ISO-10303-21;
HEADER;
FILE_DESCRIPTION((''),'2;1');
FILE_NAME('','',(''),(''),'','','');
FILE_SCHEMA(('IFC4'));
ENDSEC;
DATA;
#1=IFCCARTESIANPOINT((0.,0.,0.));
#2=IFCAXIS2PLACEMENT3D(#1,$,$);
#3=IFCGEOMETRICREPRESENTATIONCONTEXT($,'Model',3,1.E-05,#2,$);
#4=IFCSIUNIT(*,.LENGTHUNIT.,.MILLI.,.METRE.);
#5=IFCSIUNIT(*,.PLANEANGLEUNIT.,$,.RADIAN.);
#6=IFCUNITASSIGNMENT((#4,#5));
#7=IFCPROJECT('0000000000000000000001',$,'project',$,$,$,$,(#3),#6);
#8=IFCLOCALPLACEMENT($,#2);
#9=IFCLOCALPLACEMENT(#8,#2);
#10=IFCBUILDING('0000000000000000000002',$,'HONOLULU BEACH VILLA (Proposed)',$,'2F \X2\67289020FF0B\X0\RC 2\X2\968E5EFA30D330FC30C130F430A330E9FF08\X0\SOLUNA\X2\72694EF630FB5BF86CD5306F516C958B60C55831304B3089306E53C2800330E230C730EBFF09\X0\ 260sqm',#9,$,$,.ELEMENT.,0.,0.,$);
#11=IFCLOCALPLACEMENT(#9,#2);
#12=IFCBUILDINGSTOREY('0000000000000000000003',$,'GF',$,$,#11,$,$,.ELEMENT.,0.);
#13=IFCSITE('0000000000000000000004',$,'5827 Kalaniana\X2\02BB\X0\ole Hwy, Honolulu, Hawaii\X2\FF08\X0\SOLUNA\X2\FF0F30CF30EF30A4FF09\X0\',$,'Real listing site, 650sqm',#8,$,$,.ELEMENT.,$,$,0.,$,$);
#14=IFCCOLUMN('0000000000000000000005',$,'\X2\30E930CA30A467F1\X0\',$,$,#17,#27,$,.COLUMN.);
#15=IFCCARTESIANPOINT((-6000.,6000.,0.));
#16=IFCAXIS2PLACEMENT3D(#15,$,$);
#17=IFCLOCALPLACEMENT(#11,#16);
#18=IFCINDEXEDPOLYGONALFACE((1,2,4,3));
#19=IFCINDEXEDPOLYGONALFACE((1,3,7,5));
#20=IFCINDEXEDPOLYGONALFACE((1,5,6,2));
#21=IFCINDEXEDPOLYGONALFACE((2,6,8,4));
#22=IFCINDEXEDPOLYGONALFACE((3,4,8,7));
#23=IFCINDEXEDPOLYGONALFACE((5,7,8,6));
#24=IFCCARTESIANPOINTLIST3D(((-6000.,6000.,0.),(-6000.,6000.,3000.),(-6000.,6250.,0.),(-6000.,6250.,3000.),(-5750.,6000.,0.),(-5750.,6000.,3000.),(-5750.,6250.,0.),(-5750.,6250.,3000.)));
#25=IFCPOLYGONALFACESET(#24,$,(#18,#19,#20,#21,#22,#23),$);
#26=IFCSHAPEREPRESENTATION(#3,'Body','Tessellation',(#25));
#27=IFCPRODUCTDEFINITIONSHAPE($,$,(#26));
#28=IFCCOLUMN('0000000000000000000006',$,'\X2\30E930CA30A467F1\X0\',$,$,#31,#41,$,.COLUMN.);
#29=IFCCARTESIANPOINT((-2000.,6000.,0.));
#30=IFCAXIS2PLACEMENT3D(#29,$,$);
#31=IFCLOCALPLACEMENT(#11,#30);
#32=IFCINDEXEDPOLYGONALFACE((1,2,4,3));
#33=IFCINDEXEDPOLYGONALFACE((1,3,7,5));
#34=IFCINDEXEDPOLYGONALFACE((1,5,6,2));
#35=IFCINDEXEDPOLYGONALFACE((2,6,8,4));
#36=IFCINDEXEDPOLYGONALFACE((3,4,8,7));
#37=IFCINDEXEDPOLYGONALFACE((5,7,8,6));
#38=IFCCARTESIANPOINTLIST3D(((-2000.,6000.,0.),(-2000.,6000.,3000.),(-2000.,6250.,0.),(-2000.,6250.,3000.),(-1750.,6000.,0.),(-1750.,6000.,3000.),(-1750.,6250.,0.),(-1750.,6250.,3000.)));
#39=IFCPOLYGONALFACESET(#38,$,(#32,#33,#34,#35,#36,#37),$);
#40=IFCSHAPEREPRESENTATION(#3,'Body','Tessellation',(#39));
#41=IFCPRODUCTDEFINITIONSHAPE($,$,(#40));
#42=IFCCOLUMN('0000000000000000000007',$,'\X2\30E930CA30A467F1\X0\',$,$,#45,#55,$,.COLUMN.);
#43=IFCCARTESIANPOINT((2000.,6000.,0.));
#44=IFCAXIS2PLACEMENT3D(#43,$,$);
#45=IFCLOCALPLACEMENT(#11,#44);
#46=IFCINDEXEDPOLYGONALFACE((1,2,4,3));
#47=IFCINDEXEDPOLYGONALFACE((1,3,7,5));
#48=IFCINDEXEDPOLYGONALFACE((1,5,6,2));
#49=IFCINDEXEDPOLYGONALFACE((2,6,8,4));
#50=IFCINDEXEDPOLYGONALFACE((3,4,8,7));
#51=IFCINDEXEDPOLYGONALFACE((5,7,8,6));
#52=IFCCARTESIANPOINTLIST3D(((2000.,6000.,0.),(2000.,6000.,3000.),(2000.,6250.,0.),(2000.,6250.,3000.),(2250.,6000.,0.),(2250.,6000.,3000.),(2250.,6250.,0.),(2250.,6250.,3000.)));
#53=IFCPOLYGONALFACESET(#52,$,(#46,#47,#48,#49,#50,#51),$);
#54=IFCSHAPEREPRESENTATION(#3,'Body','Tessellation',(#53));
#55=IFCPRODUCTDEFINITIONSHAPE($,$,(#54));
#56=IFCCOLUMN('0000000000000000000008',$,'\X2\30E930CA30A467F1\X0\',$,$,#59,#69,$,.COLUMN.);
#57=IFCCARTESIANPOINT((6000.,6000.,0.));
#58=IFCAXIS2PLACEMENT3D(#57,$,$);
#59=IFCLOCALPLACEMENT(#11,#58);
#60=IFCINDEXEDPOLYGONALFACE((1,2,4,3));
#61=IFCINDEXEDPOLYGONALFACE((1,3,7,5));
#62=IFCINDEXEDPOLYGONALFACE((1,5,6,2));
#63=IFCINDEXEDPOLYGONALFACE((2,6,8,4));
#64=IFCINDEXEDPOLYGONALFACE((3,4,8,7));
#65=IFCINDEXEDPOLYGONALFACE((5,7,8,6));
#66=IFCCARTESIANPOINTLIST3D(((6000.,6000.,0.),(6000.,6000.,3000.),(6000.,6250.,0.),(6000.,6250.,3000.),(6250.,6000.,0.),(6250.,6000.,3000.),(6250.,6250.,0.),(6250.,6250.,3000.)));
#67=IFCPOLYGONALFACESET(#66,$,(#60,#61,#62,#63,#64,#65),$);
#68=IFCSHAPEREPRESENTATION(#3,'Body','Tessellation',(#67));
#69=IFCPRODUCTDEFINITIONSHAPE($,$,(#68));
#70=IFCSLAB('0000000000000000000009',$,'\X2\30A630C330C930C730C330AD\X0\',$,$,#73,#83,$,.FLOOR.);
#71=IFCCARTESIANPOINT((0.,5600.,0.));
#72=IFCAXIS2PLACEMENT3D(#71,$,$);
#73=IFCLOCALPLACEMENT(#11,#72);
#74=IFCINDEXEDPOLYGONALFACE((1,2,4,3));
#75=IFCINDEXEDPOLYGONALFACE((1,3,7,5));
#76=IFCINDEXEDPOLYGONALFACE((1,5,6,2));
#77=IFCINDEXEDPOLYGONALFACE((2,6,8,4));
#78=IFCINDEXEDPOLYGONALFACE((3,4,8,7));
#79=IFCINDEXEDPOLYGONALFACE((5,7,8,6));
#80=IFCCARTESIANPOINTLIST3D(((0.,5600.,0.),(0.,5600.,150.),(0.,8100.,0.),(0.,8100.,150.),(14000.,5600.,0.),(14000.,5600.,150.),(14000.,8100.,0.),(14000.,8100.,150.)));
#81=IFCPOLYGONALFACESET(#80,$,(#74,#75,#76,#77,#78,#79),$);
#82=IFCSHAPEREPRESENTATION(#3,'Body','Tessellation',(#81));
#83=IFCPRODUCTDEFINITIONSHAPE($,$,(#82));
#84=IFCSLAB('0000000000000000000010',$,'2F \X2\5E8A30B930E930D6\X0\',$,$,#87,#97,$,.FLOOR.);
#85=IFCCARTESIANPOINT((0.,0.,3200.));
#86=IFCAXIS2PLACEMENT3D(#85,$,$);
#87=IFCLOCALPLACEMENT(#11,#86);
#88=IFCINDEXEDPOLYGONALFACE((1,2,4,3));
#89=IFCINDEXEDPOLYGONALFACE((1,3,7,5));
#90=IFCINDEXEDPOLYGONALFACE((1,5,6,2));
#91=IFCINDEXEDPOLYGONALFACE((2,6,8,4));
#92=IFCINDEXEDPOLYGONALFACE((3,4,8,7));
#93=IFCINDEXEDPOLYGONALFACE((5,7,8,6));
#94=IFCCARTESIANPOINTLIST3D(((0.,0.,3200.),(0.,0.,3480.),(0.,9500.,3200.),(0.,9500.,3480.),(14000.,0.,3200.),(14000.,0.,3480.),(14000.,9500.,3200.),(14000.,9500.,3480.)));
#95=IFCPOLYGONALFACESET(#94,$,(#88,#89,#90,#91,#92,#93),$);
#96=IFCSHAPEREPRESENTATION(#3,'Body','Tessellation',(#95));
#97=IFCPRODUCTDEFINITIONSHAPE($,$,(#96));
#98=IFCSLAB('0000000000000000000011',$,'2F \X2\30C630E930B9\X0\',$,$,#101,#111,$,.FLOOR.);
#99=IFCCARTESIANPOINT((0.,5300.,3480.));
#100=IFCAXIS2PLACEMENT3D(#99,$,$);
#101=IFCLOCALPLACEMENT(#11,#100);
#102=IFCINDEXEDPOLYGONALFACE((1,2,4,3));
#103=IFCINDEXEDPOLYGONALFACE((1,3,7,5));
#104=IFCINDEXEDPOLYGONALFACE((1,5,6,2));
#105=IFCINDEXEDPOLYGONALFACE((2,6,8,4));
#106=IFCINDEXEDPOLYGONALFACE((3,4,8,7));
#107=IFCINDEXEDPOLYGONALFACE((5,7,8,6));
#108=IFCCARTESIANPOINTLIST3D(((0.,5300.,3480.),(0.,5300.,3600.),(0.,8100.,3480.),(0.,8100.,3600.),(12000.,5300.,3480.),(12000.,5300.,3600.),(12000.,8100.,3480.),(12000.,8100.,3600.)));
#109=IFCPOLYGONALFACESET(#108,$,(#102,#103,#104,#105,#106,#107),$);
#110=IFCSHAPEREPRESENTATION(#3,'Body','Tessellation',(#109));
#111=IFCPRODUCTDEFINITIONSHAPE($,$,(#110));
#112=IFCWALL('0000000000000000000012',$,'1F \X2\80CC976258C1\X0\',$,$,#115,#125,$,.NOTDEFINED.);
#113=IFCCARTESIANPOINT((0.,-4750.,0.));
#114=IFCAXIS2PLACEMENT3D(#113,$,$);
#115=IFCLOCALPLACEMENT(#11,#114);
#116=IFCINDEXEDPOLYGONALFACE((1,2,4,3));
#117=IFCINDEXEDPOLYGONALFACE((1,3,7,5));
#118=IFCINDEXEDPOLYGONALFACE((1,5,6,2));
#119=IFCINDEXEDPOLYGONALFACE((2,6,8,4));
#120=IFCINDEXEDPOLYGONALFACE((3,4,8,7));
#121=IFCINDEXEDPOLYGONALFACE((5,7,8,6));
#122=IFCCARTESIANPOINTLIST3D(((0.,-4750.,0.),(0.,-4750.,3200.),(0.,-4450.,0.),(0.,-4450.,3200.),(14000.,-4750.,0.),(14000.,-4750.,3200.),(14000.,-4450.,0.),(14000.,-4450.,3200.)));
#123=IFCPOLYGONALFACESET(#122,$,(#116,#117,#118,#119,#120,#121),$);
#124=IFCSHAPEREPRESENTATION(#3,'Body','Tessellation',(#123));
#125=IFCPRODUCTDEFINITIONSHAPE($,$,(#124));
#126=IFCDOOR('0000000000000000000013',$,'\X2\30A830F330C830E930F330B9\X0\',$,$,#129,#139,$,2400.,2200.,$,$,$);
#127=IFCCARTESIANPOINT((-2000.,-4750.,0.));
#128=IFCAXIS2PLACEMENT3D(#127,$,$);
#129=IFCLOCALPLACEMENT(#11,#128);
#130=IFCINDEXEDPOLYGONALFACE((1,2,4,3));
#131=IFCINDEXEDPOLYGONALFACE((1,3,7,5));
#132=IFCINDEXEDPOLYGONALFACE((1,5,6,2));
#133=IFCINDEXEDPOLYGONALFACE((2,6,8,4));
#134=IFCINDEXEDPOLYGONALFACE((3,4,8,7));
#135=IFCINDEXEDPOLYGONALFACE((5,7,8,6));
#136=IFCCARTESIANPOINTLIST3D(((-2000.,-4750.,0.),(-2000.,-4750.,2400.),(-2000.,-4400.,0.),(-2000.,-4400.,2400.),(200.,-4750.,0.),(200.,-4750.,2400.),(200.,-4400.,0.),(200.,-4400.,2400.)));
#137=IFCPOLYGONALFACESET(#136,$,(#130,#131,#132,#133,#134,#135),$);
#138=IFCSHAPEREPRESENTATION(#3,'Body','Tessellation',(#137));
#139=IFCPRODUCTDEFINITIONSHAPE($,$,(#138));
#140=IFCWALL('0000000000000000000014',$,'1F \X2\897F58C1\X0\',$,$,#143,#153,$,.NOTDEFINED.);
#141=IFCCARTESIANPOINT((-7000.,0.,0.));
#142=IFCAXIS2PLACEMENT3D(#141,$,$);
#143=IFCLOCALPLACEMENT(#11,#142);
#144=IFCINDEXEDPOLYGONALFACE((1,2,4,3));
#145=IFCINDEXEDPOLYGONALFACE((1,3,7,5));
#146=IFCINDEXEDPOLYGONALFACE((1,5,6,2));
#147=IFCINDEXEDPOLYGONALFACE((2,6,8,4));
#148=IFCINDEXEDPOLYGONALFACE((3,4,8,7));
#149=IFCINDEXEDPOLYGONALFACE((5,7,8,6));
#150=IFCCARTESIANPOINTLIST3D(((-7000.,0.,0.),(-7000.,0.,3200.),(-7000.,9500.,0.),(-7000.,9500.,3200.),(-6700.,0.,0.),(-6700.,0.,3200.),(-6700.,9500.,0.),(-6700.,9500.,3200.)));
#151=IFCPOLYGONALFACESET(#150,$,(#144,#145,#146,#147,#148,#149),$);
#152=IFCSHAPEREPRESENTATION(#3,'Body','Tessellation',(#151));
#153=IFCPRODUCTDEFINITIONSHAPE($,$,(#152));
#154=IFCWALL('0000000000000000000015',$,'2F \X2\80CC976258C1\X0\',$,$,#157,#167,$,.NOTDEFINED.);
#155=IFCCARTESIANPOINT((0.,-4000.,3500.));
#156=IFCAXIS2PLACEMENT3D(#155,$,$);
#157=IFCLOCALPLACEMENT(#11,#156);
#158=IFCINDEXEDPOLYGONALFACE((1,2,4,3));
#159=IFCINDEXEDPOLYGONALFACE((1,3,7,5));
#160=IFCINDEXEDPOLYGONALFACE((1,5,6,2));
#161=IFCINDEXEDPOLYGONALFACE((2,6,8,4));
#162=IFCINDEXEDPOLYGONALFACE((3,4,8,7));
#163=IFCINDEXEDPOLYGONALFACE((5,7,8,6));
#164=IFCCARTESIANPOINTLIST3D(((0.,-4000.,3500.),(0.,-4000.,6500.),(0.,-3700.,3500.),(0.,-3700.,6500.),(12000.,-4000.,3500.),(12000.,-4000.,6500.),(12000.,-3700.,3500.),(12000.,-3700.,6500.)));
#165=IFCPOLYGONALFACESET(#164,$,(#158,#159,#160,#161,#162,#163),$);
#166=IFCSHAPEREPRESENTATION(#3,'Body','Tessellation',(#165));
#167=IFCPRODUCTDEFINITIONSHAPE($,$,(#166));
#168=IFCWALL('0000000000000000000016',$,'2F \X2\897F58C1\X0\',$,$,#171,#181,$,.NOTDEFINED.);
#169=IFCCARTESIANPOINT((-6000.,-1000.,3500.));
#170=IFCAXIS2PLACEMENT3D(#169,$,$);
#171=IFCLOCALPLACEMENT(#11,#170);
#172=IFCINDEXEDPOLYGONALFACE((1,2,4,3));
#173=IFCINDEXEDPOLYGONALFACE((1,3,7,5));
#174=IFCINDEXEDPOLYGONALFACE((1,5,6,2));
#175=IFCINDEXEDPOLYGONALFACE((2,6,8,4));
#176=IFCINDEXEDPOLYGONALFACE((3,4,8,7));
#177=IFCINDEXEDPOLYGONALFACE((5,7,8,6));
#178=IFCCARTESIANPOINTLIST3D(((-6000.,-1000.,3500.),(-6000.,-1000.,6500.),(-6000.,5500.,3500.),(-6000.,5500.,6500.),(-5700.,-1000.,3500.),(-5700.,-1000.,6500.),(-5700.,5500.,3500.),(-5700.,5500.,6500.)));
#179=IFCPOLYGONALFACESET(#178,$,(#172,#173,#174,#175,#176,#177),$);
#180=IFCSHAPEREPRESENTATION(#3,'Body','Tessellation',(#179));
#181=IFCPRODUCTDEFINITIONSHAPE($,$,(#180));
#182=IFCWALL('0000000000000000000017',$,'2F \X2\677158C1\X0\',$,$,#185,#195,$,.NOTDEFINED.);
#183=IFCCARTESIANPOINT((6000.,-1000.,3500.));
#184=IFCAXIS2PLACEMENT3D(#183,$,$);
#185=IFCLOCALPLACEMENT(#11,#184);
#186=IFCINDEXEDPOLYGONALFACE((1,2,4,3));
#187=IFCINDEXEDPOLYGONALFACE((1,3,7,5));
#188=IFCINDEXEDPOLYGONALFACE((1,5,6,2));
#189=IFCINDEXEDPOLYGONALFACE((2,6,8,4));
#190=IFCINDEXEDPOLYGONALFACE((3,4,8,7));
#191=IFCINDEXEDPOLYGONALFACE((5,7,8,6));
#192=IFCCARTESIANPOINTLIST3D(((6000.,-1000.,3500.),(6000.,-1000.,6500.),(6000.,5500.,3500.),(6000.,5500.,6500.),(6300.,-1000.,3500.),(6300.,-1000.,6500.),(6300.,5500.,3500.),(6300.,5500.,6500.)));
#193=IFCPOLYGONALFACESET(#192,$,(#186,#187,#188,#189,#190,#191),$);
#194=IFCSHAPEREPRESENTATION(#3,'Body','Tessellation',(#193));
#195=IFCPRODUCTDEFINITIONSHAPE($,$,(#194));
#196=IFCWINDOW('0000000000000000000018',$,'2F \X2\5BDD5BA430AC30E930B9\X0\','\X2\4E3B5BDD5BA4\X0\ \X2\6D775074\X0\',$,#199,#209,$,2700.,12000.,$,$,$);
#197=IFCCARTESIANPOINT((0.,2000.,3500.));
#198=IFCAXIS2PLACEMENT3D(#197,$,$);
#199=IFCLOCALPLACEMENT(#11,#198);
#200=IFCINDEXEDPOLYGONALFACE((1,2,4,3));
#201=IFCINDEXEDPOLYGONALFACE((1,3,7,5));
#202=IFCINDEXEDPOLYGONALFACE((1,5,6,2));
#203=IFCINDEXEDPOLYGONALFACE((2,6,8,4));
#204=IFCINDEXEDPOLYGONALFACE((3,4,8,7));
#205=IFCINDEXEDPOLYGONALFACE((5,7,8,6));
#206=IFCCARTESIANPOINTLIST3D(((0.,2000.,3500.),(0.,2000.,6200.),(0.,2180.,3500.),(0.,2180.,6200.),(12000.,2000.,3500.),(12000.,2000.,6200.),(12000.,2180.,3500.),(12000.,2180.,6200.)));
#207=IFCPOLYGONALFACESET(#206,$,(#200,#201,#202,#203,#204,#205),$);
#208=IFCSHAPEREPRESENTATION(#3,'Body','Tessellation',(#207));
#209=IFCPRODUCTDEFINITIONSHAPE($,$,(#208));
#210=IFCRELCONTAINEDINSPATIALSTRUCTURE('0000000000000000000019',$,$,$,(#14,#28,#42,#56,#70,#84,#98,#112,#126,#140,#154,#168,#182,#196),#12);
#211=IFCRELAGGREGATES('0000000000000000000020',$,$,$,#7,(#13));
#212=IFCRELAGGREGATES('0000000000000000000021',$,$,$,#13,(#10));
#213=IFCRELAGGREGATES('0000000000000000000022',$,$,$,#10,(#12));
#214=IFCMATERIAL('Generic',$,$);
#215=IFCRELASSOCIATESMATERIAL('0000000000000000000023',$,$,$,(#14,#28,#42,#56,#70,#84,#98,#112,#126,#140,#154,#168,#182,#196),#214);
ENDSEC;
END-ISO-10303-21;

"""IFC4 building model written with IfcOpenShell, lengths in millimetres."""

from ifc_helpers import new_model, si_unit, frame, frame_2d, origin, place, context, project, spatial, rectangle, extrude, material, element, fill, save


model = new_model("IFC4")

# Units and contexts
model_context = context("Model", 3, precision=1e-05, world=origin())
ifc_project = project(units=[si_unit("LENGTHUNIT", "METRE", prefix="MILLI"), si_unit("PLANEANGLEUNIT", "RADIAN")], contexts=[model_context])

# Site, building, storey
site_placement = place(None, origin())
site = spatial("IfcSite", under=ifc_project, at=site_placement, Name="5827 Kalanianaʻole Hwy, Honolulu, Hawaii（SOLUNA／ハワイ）", ObjectType="Real listing site, 650sqm", CompositionType="ELEMENT", RefElevation=0.0)
building_placement = place(site_placement, origin())
building = spatial("IfcBuilding", under=site, at=building_placement, Name="HONOLULU BEACH VILLA (Proposed)", ObjectType="2F 木造＋RC 2階建ビーチヴィラ（SOLUNA物件・寸法は公開情報からの参考モデル） 260sqm", CompositionType="ELEMENT", ElevationOfRefHeight=0.0, ElevationOfTerrain=0.0)
storey_placement = place(building_placement, origin())
storey = spatial("IfcBuildingStorey", under=building, at=storey_placement, Name="GF", CompositionType="ELEMENT", Elevation=0.0)

# Columns
ifc_material_1 = material(Name="Generic")
column_1_placement = place(storey_placement, frame((-6000.0, 6000.0, 0.0)))
element("IfcColumn", 1, at=column_1_placement, inside=storey, material=ifc_material_1, Name="ラナイ柱", PredefinedType="COLUMN", context=model_context, shape_type="SweptSolid", body=[
    extrude(rectangle(XDim=250.0, YDim=250.0, at=frame_2d((125.0, 125.0))), frame((-6000.0, 6000.0, 0.0)), (0.0, 0.0, 1.0), 3000.0),
])
column_2_placement = place(storey_placement, frame((-2000.0, 6000.0, 0.0)))
element("IfcColumn", 2, at=column_2_placement, inside=storey, material=ifc_material_1, Name="ラナイ柱", PredefinedType="COLUMN", context=model_context, shape_type="SweptSolid", body=[
    extrude(rectangle(XDim=250.0, YDim=250.0, at=frame_2d((125.0, 125.0))), frame((-2000.0, 6000.0, 0.0)), (0.0, 0.0, 1.0), 3000.0),
])
column_3_placement = place(storey_placement, frame((2000.0, 6000.0, 0.0)))
element("IfcColumn", 3, at=column_3_placement, inside=storey, material=ifc_material_1, Name="ラナイ柱", PredefinedType="COLUMN", context=model_context, shape_type="SweptSolid", body=[
    extrude(rectangle(XDim=250.0, YDim=250.0, at=frame_2d((125.0, 125.0))), frame((2000.0, 6000.0, 0.0)), (0.0, 0.0, 1.0), 3000.0),
])
column_4_placement = place(storey_placement, frame((6000.0, 6000.0, 0.0)))
element("IfcColumn", 4, at=column_4_placement, inside=storey, material=ifc_material_1, Name="ラナイ柱", PredefinedType="COLUMN", context=model_context, shape_type="SweptSolid", body=[
    extrude(rectangle(XDim=250.0, YDim=250.0, at=frame_2d((125.0, 125.0))), frame((6000.0, 6000.0, 0.0)), (0.0, 0.0, 1.0), 3000.0),
])

# Slabs
slab_1_placement = place(storey_placement, frame((0.0, 5600.0, 0.0)))
element("IfcSlab", 5, at=slab_1_placement, inside=storey, material=ifc_material_1, Name="ウッドデッキ", PredefinedType="FLOOR", context=model_context, shape_type="SweptSolid", body=[
    extrude(rectangle(XDim=14000.0, YDim=2500.0, at=frame_2d((7000.0, 1250.0))), frame((0.0, 5600.0, 0.0)), (0.0, 0.0, 1.0), 150.0),
])
slab_2_placement = place(storey_placement, frame((0.0, 0.0, 3200.0)))
element("IfcSlab", 6, at=slab_2_placement, inside=storey, material=ifc_material_1, Name="2F 床スラブ", PredefinedType="FLOOR", context=model_context, shape_type="SweptSolid", body=[
    extrude(rectangle(XDim=14000.0, YDim=9500.0, at=frame_2d((7000.0, 4750.0))), frame((0.0, 0.0, 3200.0)), (0.0, 0.0, 1.0), 280.0),
])
slab_3_placement = place(storey_placement, frame((0.0, 5300.0, 3480.0)))
element("IfcSlab", 7, at=slab_3_placement, inside=storey, material=ifc_material_1, Name="2F テラス", PredefinedType="FLOOR", context=model_context, shape_type="SweptSolid", body=[
    extrude(rectangle(XDim=12000.0, YDim=2800.0, at=frame_2d((6000.0, 1400.0))), frame((0.0, 5300.0, 3480.0)), (0.0, 0.0, 1.0), 120.0),
])

# Wall, opening, door
wall_1_placement = place(storey_placement, frame((0.0, -4750.0, 0.0)))
wall_1 = element("IfcWall", 8, at=wall_1_placement, inside=storey, material=ifc_material_1, Name="1F 背面壁", PredefinedType="NOTDEFINED", context=model_context, shape_type="SweptSolid", body=[
    extrude(rectangle(XDim=14000.0, YDim=300.0, at=frame_2d((7000.0, 150.0))), frame((0.0, -4750.0, 0.0)), (0.0, 0.0, 1.0), 3200.0),
])
opening_1_placement = place(storey_placement, frame((-2000.0, -4750.0, 0.0)))
opening_1 = element("IfcOpeningElement", 9, at=opening_1_placement, cuts=wall_1, PredefinedType="NOTDEFINED", context=model_context, shape_type="SweptSolid", body=[
    extrude(rectangle(XDim=2200.0, YDim=350.0, at=frame_2d((1100.0, 175.0))), frame((-2000.0, -4750.0, 0.0)), (0.0, 0.0, 1.0), 2400.0),
])
door_placement = place(storey_placement, frame((-2000.0, -4750.0, 0.0)))
door = element("IfcDoor", 10, at=door_placement, inside=storey, material=ifc_material_1, Name="エントランス", OverallHeight=2400.0, OverallWidth=2200.0, context=model_context, shape_type="SweptSolid", body=[
    extrude(rectangle(XDim=2200.0, YDim=350.0, at=frame_2d((1100.0, 175.0))), frame((-2000.0, -4750.0, 0.0)), (0.0, 0.0, 1.0), 2400.0),
])
fill(opening_1, door)

# Wall
wall_2_placement = place(storey_placement, frame((-7000.0, 0.0, 0.0)))
element("IfcWall", 11, at=wall_2_placement, inside=storey, material=ifc_material_1, Name="1F 西壁", PredefinedType="NOTDEFINED", context=model_context, shape_type="SweptSolid", body=[
    extrude(rectangle(XDim=300.0, YDim=9500.0, at=frame_2d((150.0, 4750.0))), frame((-7000.0, 0.0, 0.0)), (0.0, 0.0, 1.0), 3200.0),
])

# Walls
wall_3_placement = place(storey_placement, frame((0.0, -4000.0, 3500.0)))
element("IfcWall", 12, at=wall_3_placement, inside=storey, material=ifc_material_1, Name="2F 背面壁", PredefinedType="NOTDEFINED", context=model_context, shape_type="SweptSolid", body=[
    extrude(rectangle(XDim=12000.0, YDim=300.0, at=frame_2d((6000.0, 150.0))), frame((0.0, -4000.0, 3500.0)), (0.0, 0.0, 1.0), 3000.0),
])
wall_4_placement = place(storey_placement, frame((-6000.0, -1000.0, 3500.0)))
element("IfcWall", 13, at=wall_4_placement, inside=storey, material=ifc_material_1, Name="2F 西壁", PredefinedType="NOTDEFINED", context=model_context, shape_type="SweptSolid", body=[
    extrude(rectangle(XDim=300.0, YDim=6500.0, at=frame_2d((150.0, 3250.0))), frame((-6000.0, -1000.0, 3500.0)), (0.0, 0.0, 1.0), 3000.0),
])

# Wall, opening, window
wall_5_placement = place(storey_placement, frame((6000.0, -1000.0, 3500.0)))
wall_5 = element("IfcWall", 14, at=wall_5_placement, inside=storey, material=ifc_material_1, Name="2F 東壁", PredefinedType="NOTDEFINED", context=model_context, shape_type="SweptSolid", body=[
    extrude(rectangle(XDim=300.0, YDim=6500.0, at=frame_2d((150.0, 3250.0))), frame((6000.0, -1000.0, 3500.0)), (0.0, 0.0, 1.0), 3000.0),
])
opening_2_placement = place(storey_placement, frame((0.0, 2000.0, 3500.0)))
opening_2 = element("IfcOpeningElement", 15, at=opening_2_placement, cuts=wall_5, PredefinedType="NOTDEFINED", context=model_context, shape_type="SweptSolid", body=[
    extrude(rectangle(XDim=12000.0, YDim=180.0, at=frame_2d((6000.0, 90.0))), frame((0.0, 2000.0, 3500.0)), (0.0, 0.0, 1.0), 2700.0),
])
window_1_placement = place(storey_placement, frame((0.0, 2000.0, 3500.0)))
window_1 = element("IfcWindow", 16, at=window_1_placement, inside=storey, material=ifc_material_1, Name="2F 寝室ガラス", Description="主寝室 海側", OverallHeight=2700.0, OverallWidth=12000.0, context=model_context, shape_type="SweptSolid", body=[
    extrude(rectangle(XDim=12000.0, YDim=180.0, at=frame_2d((6000.0, 90.0))), frame((0.0, 2000.0, 3500.0)), (0.0, 0.0, 1.0), 2700.0),
])
fill(opening_2, window_1)

save(model, "model.ifc")
